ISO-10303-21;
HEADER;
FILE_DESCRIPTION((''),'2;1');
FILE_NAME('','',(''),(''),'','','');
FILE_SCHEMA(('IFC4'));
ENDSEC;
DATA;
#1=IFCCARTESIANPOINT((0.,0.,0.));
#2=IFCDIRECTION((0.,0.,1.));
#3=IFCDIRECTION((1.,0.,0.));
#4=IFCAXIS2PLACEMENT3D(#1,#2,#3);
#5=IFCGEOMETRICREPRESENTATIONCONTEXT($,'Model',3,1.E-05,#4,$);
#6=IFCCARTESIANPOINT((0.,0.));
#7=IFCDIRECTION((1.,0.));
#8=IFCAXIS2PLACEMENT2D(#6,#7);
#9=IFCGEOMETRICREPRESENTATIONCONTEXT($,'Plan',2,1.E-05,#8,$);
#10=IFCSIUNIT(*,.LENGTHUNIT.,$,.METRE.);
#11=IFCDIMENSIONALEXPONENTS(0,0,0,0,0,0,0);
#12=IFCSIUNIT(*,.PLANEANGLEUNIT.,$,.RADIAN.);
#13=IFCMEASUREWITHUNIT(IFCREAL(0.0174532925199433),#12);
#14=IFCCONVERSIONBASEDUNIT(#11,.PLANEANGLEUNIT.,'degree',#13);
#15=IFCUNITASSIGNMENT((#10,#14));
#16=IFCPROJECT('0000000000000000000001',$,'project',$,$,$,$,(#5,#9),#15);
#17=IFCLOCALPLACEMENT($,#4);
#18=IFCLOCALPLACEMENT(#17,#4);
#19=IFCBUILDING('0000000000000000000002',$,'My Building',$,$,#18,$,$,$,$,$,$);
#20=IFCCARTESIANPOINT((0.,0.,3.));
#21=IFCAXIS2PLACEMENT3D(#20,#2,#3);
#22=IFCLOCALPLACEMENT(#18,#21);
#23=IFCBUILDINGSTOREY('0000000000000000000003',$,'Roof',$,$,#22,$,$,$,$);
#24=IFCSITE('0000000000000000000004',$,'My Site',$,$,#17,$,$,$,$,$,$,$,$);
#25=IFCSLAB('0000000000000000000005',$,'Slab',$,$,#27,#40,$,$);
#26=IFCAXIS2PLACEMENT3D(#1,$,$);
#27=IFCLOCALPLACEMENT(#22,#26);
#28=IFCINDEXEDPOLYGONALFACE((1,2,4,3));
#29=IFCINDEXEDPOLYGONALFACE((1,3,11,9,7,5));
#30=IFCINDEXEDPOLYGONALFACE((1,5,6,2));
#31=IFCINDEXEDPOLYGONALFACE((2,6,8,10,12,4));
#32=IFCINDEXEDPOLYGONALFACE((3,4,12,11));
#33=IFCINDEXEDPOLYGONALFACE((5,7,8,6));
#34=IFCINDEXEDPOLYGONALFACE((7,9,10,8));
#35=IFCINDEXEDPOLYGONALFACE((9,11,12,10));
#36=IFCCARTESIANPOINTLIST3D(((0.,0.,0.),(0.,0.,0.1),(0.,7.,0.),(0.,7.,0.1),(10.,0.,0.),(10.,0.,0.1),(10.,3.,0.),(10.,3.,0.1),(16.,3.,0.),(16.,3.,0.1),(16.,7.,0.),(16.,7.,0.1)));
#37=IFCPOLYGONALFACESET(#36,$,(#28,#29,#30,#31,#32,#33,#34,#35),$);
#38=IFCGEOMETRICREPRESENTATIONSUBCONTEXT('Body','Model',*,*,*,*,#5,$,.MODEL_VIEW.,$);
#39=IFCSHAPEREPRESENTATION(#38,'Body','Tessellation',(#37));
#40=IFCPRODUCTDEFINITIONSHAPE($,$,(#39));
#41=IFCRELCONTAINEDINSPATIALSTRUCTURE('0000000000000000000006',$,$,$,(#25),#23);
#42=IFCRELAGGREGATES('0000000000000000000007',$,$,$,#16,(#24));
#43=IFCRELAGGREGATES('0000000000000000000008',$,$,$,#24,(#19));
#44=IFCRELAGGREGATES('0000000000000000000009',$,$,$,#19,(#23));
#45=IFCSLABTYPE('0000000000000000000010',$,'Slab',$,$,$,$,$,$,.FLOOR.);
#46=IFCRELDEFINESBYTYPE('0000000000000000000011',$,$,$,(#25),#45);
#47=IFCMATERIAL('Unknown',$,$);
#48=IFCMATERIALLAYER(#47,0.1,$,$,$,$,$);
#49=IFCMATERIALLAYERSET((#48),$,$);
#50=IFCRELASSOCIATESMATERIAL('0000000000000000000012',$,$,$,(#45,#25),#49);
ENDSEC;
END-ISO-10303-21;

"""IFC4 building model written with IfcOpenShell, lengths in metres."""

from ifc_helpers import new_model, entity, si_unit, converted_unit, frame, origin_with_axes, origin_2d_with_axis, place, context, subcontext, project, spatial, indexed_curve, outline, extrude, material, layer, layer_set, layer_usage, type_object, element, save


model = new_model("IFC4")

# Units and contexts
model_context = context("Model", 3, precision=1e-05, world=origin_with_axes())
plan_context = context("Plan", 2, precision=1e-05, world=origin_2d_with_axis())
body_context = subcontext(model_context, "Body", "Model", "MODEL_VIEW")
ifc_project = project(units=[si_unit("LENGTHUNIT", "METRE"), converted_unit("PLANEANGLEUNIT", "degree", entity("IfcReal", 0.0174532925199433), si_unit("PLANEANGLEUNIT", "RADIAN"), dimensions=[0, 0, 0, 0, 0, 0, 0])], contexts=[model_context, plan_context])

# Site, building, storey
site_placement = place(None, origin_with_axes())
site = spatial("IfcSite", under=ifc_project, at=site_placement, Name="My Site")
building_placement = place(site_placement, origin_with_axes())
building = spatial("IfcBuilding", under=site, at=building_placement, Name="My Building")
storey_placement = place(building_placement, frame((0.0, 0.0, 3.0), z_axis=(0.0, 0.0, 1.0), x_axis=(1.0, 0.0, 0.0)))
storey = spatial("IfcBuildingStorey", under=building, at=storey_placement, Name="Roof")

# Slab
ifc_material = material(Name="Unknown")
ifc_layer = layer(ifc_material, 0.1)
ifc_layer_set = layer_set([ifc_layer])
ifc_layer_usage = layer_usage(ifc_layer_set, "AXIS3", "POSITIVE", -0.1)
slab_type = type_object("IfcSlabType", Name="Slab", PredefinedType="FLOOR", material=ifc_layer_set)
slab_placement = place(storey_placement, frame((0.0, 7.0, 0.1), z_axis=(0.0, 0.0, 1.0), x_axis=(1.0, 0.0, 0.0)))
element("IfcSlab", 1, at=slab_placement, inside=storey, type_object=slab_type, material=ifc_layer_usage, Name="Slab", context=body_context, shape_type="SweptSolid", body=[
    extrude(outline(indexed_curve([(0.0, 0.0), (0.0, -7.0), (10.0, -7.0), (10.0, -4.0), (16.0, -4.0), (16.0, 0.0), (0.0, 0.0)])), frame((0.0, 0.0, -0.1), z_axis=(0.0, 0.0, 1.0), x_axis=(1.0, 0.0, 0.0)), (0.0, 0.0, 1.0), 0.1),
])

save(model, "model.ifc")
